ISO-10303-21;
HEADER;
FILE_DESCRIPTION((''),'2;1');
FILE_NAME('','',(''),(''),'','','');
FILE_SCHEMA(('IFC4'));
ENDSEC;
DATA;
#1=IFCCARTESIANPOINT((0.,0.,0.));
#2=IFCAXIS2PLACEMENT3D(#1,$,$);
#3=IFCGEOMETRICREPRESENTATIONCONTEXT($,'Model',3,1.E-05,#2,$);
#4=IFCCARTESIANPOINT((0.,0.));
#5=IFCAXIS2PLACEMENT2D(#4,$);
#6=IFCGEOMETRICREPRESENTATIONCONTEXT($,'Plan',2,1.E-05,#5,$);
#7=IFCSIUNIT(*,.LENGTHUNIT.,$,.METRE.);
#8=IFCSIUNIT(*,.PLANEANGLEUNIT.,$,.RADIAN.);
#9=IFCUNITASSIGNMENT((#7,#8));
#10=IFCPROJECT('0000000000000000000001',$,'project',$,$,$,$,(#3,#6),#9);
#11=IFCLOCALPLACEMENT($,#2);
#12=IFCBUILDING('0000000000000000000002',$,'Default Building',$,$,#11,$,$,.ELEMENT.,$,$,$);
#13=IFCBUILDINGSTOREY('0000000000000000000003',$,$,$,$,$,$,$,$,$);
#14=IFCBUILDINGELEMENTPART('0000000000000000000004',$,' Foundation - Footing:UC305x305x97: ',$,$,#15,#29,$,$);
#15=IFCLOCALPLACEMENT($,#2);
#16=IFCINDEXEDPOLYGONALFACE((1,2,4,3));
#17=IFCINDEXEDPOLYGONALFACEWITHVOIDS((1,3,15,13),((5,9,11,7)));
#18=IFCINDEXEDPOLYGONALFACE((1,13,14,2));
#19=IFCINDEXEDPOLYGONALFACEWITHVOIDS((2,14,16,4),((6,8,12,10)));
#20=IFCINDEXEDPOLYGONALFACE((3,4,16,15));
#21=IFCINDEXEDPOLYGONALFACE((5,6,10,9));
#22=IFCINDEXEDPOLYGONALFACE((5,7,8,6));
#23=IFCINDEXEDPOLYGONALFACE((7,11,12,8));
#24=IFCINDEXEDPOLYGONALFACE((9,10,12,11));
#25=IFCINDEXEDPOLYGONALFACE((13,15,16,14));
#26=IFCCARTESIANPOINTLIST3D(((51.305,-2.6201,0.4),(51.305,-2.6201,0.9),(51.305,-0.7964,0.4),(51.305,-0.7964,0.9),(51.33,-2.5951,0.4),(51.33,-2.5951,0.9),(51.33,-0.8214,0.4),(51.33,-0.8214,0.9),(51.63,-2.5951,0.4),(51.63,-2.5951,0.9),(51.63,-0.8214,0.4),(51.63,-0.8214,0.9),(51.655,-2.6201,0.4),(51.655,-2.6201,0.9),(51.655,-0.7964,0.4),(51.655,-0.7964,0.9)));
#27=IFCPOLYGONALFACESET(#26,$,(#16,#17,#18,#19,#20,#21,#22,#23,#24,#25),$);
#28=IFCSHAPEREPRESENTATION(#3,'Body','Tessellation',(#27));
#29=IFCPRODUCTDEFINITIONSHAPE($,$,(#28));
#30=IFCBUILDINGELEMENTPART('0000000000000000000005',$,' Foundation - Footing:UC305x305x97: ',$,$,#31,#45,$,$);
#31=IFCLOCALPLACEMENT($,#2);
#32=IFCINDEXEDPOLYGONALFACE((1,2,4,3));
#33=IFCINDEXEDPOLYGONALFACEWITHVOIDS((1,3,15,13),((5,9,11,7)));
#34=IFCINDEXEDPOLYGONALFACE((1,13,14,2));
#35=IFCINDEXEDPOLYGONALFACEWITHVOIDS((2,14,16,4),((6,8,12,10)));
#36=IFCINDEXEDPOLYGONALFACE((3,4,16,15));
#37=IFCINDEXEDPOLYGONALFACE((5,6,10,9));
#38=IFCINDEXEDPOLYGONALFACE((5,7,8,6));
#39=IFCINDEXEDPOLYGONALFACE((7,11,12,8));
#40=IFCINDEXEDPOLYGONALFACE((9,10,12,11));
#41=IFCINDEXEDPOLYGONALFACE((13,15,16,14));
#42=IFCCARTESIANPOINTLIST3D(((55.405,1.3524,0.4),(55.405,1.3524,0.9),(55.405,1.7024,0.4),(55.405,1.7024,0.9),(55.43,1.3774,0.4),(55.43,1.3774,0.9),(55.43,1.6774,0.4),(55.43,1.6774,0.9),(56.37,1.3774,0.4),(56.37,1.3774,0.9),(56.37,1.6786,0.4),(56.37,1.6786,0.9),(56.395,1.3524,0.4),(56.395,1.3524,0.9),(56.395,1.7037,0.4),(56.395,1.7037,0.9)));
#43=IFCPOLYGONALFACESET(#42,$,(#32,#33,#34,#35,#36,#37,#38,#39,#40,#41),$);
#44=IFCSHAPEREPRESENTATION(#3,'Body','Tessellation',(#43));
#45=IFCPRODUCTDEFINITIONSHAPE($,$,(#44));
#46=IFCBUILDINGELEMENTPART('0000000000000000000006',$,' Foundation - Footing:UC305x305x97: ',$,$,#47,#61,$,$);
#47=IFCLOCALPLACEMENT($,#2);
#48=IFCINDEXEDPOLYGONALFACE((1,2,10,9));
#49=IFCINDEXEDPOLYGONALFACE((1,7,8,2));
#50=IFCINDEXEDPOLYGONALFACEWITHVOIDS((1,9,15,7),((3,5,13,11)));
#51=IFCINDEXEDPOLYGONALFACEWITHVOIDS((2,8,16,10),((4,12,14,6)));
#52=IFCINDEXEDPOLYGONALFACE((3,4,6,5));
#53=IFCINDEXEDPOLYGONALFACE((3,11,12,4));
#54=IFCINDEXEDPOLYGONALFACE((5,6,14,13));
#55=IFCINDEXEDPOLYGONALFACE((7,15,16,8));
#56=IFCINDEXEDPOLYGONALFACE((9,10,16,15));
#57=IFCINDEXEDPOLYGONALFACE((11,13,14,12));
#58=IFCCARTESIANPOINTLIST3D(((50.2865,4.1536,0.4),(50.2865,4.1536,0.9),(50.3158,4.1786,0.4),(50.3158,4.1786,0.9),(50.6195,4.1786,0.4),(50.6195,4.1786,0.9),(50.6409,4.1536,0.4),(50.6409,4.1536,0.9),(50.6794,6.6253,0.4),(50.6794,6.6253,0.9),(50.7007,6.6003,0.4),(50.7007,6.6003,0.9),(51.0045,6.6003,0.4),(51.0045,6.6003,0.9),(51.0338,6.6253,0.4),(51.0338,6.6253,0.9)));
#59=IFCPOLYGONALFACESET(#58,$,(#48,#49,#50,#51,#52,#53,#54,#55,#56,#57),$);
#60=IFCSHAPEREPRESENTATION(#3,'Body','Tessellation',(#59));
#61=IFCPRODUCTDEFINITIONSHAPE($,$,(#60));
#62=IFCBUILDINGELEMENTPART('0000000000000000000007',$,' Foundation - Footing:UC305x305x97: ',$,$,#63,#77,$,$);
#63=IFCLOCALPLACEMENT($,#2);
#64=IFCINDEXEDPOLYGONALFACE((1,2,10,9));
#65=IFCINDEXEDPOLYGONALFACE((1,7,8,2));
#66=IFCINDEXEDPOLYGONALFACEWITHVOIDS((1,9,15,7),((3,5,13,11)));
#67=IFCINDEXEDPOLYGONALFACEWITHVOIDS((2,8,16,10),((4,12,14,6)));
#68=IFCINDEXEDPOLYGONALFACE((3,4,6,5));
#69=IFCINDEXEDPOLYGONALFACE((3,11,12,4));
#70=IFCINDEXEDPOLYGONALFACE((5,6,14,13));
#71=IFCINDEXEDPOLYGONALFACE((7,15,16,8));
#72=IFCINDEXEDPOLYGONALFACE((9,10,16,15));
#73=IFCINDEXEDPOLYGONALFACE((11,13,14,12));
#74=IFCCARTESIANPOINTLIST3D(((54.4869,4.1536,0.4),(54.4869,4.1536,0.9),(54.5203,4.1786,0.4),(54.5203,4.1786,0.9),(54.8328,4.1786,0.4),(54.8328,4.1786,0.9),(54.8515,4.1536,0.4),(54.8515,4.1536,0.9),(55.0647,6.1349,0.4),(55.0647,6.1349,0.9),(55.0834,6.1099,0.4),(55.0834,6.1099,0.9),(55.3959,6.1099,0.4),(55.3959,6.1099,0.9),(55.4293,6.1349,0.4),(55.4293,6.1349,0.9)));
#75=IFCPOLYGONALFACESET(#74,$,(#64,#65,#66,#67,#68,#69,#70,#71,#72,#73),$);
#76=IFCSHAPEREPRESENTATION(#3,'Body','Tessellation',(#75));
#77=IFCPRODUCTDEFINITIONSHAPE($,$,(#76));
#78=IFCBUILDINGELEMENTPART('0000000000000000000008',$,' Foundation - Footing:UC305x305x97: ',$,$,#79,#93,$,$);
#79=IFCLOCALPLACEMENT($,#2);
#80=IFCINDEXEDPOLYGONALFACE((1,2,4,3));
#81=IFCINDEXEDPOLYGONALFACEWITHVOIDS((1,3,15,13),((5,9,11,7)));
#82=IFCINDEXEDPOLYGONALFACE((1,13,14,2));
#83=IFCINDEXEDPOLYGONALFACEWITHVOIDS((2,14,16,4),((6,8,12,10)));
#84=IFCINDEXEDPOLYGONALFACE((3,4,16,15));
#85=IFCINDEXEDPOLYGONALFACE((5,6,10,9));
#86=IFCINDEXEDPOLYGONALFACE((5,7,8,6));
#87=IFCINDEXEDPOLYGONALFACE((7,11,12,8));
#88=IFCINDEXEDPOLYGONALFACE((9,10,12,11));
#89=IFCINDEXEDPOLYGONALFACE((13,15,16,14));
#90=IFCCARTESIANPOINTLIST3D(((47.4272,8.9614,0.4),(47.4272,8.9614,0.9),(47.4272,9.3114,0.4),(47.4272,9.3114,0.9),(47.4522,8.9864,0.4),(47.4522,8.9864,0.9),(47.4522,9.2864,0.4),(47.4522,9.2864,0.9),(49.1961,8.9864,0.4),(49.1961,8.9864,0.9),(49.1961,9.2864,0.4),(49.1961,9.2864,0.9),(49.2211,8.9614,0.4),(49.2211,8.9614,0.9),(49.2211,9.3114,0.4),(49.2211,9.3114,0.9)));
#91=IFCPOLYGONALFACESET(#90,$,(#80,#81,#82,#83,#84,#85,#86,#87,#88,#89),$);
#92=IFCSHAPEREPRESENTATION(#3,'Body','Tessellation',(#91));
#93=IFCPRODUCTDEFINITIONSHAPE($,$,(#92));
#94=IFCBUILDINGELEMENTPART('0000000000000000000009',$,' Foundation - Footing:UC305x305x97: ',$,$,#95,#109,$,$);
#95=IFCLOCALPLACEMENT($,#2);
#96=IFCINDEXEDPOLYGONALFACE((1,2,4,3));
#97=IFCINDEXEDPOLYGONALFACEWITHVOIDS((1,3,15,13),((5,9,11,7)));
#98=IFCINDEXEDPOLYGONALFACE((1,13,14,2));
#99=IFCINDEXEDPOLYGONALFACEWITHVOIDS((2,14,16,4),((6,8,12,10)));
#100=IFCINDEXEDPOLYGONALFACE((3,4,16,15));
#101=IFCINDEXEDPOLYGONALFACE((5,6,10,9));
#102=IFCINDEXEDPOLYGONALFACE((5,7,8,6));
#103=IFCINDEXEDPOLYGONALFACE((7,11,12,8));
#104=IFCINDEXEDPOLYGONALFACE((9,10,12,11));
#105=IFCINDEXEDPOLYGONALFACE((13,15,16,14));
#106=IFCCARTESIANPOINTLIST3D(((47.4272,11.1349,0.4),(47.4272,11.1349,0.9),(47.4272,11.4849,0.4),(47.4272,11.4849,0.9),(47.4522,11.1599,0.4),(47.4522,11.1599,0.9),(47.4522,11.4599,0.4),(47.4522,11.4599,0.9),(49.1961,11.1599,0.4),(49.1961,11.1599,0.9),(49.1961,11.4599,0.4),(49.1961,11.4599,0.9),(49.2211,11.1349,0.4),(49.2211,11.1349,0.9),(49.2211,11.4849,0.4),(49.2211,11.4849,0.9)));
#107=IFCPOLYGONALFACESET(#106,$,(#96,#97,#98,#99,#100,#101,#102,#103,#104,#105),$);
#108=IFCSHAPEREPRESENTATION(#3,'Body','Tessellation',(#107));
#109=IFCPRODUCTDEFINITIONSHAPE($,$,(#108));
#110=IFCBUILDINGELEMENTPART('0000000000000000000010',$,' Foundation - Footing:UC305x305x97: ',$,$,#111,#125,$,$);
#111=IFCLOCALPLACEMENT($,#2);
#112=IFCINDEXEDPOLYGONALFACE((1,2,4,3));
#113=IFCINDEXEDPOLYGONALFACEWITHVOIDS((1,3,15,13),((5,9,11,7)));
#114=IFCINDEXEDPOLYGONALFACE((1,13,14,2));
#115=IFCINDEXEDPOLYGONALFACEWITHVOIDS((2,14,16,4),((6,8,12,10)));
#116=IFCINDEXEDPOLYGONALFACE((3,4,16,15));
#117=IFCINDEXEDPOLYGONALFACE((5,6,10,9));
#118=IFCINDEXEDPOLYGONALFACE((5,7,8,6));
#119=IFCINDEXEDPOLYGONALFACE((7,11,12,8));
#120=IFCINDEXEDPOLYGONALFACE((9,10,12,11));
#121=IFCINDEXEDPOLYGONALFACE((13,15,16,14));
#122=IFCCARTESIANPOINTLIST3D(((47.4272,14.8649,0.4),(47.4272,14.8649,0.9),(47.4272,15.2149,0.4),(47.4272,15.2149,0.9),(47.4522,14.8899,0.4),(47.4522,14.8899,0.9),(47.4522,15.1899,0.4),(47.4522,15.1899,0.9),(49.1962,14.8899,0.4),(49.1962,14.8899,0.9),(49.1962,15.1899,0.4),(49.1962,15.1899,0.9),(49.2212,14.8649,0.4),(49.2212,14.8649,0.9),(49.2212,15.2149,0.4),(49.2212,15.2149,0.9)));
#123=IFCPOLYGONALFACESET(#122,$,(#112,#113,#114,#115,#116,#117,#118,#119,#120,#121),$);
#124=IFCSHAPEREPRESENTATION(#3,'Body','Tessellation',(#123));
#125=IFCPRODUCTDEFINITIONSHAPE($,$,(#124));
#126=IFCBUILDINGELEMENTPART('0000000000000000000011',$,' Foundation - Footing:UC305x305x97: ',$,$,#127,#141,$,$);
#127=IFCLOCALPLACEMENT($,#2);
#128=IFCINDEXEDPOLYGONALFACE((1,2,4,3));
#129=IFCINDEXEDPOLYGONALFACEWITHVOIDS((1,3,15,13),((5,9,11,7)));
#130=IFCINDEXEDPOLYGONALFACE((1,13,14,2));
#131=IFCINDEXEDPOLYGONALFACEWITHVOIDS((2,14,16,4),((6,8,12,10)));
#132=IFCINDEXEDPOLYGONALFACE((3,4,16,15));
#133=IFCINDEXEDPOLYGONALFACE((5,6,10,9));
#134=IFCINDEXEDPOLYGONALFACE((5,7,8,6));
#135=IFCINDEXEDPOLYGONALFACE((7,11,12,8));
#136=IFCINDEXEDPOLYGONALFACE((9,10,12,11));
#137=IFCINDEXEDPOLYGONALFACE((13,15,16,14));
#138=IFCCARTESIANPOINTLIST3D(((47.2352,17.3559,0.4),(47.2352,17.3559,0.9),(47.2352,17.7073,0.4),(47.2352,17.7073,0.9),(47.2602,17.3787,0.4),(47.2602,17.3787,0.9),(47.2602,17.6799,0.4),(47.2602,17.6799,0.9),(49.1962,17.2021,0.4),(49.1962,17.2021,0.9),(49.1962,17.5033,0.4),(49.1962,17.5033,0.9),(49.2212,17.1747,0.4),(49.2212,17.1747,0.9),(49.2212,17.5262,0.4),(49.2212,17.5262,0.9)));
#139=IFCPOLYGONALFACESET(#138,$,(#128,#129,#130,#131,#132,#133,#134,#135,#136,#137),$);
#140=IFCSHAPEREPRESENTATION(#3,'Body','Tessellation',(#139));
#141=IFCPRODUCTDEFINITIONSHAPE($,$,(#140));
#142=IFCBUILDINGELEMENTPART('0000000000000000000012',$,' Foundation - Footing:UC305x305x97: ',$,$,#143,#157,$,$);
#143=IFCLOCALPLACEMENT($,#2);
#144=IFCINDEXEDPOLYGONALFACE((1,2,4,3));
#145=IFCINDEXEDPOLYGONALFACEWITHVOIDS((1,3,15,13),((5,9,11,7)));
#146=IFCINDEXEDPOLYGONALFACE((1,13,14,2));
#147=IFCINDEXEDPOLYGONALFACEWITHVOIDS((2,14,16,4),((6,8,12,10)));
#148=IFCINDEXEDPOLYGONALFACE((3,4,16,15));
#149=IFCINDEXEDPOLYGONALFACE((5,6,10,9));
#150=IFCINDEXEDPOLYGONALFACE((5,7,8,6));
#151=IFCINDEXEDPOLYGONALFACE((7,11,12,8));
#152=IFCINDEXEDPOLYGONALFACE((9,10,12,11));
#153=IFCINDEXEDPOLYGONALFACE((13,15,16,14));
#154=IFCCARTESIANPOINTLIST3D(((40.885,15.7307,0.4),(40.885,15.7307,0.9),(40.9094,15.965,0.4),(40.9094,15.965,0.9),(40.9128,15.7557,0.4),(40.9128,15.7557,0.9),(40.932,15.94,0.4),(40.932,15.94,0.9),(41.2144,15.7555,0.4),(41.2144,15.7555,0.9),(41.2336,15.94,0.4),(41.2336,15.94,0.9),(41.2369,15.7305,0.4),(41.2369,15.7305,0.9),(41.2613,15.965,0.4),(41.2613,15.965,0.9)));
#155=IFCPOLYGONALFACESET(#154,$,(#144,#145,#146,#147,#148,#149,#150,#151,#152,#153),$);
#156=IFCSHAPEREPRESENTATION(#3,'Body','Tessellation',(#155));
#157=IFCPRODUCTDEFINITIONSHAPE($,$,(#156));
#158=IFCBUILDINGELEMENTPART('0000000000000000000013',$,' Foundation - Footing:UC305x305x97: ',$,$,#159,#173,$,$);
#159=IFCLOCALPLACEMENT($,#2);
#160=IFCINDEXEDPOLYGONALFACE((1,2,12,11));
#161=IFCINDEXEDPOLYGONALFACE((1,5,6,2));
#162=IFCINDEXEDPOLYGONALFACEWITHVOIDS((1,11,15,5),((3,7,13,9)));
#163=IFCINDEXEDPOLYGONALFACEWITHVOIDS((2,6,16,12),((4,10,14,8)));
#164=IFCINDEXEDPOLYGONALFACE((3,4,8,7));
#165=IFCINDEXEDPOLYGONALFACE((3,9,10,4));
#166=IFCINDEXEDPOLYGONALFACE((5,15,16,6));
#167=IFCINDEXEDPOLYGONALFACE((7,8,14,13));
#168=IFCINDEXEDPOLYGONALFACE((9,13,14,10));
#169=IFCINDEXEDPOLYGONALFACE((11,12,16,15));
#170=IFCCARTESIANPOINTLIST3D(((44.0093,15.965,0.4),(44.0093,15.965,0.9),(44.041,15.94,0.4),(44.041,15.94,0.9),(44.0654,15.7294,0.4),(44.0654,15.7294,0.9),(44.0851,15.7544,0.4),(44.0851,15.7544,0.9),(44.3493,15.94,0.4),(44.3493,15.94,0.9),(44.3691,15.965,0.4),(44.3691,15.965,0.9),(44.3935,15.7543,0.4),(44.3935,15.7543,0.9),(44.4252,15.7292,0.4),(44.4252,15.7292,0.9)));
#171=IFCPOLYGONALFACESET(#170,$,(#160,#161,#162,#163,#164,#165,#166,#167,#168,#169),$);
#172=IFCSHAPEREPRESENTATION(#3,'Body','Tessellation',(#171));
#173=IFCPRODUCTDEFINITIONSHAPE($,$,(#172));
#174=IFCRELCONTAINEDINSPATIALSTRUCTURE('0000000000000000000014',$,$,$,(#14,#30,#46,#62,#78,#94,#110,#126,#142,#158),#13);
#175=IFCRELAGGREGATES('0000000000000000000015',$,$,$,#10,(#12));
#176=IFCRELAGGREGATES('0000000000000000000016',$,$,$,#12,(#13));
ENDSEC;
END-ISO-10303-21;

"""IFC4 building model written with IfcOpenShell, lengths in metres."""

from ifc_helpers import new_model, si_unit, origin, origin_2d, place, context, project, spatial, polyline, outline, extrude, element, save


model = new_model("IFC4")

# Units and contexts
model_context = context("Model", 3, precision=1e-05, world=origin())
plan_context = context("Plan", 2, precision=1e-05, world=origin_2d())
ifc_project = project(units=[si_unit("LENGTHUNIT", "METRE"), si_unit("PLANEANGLEUNIT", "RADIAN")], contexts=[model_context, plan_context])

# Building, storey
building_placement = place(None, origin())
building = spatial("IfcBuilding", under=ifc_project, at=building_placement, Name="Default Building", CompositionType="ELEMENT")
storey = spatial("IfcBuildingStorey", under=building)

# Building element parts, openings
building_element_part_1 = element("IfcBuildingElementPart", 1, inside=storey, Name=" Foundation - Footing:UC305x305x97: ", context=model_context, shape_type="SweptSolid", body=[
    extrude(outline(polyline([(51.305, -2.6201, 0.4), (51.655, -2.6201, 0.4), (51.655, -0.7964, 0.4), (51.305, -0.7964, 0.4), (51.305, -2.6201, 0.4)])), None, (0.0, 0.0, 1.0), 0.5),
])
element("IfcOpeningElement", 2, inside=storey, cuts=building_element_part_1, context=model_context, shape_type="SweptSolid", body=[
    extrude(outline(polyline([(51.33, -2.5951, 0.4), (51.63, -2.5951, 0.4), (51.63, -0.8214, 0.4), (51.33, -0.8214, 0.4), (51.33, -2.5951, 0.4)])), None, (0.0, 0.0, 1.0), 0.5),
])
building_element_part_2 = element("IfcBuildingElementPart", 3, inside=storey, Name=" Foundation - Footing:UC305x305x97: ", context=model_context, shape_type="SweptSolid", body=[
    extrude(outline(polyline([(55.405, 1.3524, 0.4), (55.405, 1.7024, 0.4), (56.395, 1.7037, 0.4), (56.395, 1.3524, 0.4), (55.405, 1.3524, 0.4)])), None, (0.0, 0.0, 1.0), 0.5),
])
element("IfcOpeningElement", 4, inside=storey, cuts=building_element_part_2, context=model_context, shape_type="SweptSolid", body=[
    extrude(outline(polyline([(55.43, 1.3774, 0.4), (55.43, 1.6774, 0.4), (56.37, 1.6786, 0.4), (56.37, 1.3774, 0.4), (55.43, 1.3774, 0.4)])), None, (0.0, 0.0, 1.0), 0.5),
])
building_element_part_3 = element("IfcBuildingElementPart", 5, inside=storey, Name=" Foundation - Footing:UC305x305x97: ", context=model_context, shape_type="SweptSolid", body=[
    extrude(outline(polyline([(50.2865, 4.1536, 0.4), (50.6794, 6.6253, 0.4), (51.0338, 6.6253, 0.4), (50.6409, 4.1536, 0.4), (50.2865, 4.1536, 0.4)])), None, (0.0, 0.0, 1.0), 0.5),
])
element("IfcOpeningElement", 6, inside=storey, cuts=building_element_part_3, context=model_context, shape_type="SweptSolid", body=[
    extrude(outline(polyline([(50.3158, 4.1786, 0.4), (50.7007, 6.6003, 0.4), (51.0045, 6.6003, 0.4), (50.6195, 4.1786, 0.4), (50.3158, 4.1786, 0.4)])), None, (0.0, 0.0, 1.0), 0.5),
])
building_element_part_4 = element("IfcBuildingElementPart", 7, inside=storey, Name=" Foundation - Footing:UC305x305x97: ", context=model_context, shape_type="SweptSolid", body=[
    extrude(outline(polyline([(54.8515, 4.1536, 0.4), (54.4869, 4.1536, 0.4), (55.0647, 6.1349, 0.4), (55.4293, 6.1349, 0.4), (54.8515, 4.1536, 0.4)])), None, (0.0, 0.0, 1.0), 0.5),
])
element("IfcOpeningElement", 8, inside=storey, cuts=building_element_part_4, context=model_context, shape_type="SweptSolid", body=[
    extrude(outline(polyline([(54.8328, 4.1786, 0.4), (54.5203, 4.1786, 0.4), (55.0834, 6.1099, 0.4), (55.3959, 6.1099, 0.4), (54.8328, 4.1786, 0.4)])), None, (0.0, 0.0, 1.0), 0.5),
])
building_element_part_5 = element("IfcBuildingElementPart", 9, inside=storey, Name=" Foundation - Footing:UC305x305x97: ", context=model_context, shape_type="SweptSolid", body=[
    extrude(outline(polyline([(47.4272, 8.9614, 0.4), (49.2211, 8.9614, 0.4), (49.2211, 9.3114, 0.4), (47.4272, 9.3114, 0.4), (47.4272, 8.9614, 0.4)])), None, (0.0, 0.0, 1.0), 0.5),
])
element("IfcOpeningElement", 10, inside=storey, cuts=building_element_part_5, context=model_context, shape_type="SweptSolid", body=[
    extrude(outline(polyline([(47.4522, 8.9864, 0.4), (49.1961, 8.9864, 0.4), (49.1961, 9.2864, 0.4), (47.4522, 9.2864, 0.4), (47.4522, 8.9864, 0.4)])), None, (0.0, 0.0, 1.0), 0.5),
])
building_element_part_6 = element("IfcBuildingElementPart", 11, inside=storey, Name=" Foundation - Footing:UC305x305x97: ", context=model_context, shape_type="SweptSolid", body=[
    extrude(outline(polyline([(47.4272, 11.1349, 0.4), (47.4272, 11.4849, 0.4), (49.2211, 11.4849, 0.4), (49.2211, 11.1349, 0.4), (47.4272, 11.1349, 0.4)])), None, (0.0, 0.0, 1.0), 0.5),
])
element("IfcOpeningElement", 12, inside=storey, cuts=building_element_part_6, context=model_context, shape_type="SweptSolid", body=[
    extrude(outline(polyline([(47.4522, 11.1599, 0.4), (47.4522, 11.4599, 0.4), (49.1961, 11.4599, 0.4), (49.1961, 11.1599, 0.4), (47.4522, 11.1599, 0.4)])), None, (0.0, 0.0, 1.0), 0.5),
])
building_element_part_7 = element("IfcBuildingElementPart", 13, inside=storey, Name=" Foundation - Footing:UC305x305x97: ", context=model_context, shape_type="SweptSolid", body=[
    extrude(outline(polyline([(47.4272, 14.8649, 0.4), (47.4272, 15.2149, 0.4), (49.2212, 15.2149, 0.4), (49.2212, 14.8649, 0.4), (47.4272, 14.8649, 0.4)])), None, (0.0, 0.0, 1.0), 0.5),
])
element("IfcOpeningElement", 14, inside=storey, cuts=building_element_part_7, context=model_context, shape_type="SweptSolid", body=[
    extrude(outline(polyline([(47.4522, 14.8899, 0.4), (47.4522, 15.1899, 0.4), (49.1962, 15.1899, 0.4), (49.1962, 14.8899, 0.4), (47.4522, 14.8899, 0.4)])), None, (0.0, 0.0, 1.0), 0.5),
])
building_element_part_8 = element("IfcBuildingElementPart", 15, inside=storey, Name=" Foundation - Footing:UC305x305x97: ", context=model_context, shape_type="SweptSolid", body=[
    extrude(outline(polyline([(47.2352, 17.3559, 0.4), (47.2352, 17.7073, 0.4), (49.2212, 17.5262, 0.4), (49.2212, 17.1747, 0.4), (47.2352, 17.3559, 0.4)])), None, (0.0, 0.0, 1.0), 0.5),
])
element("IfcOpeningElement", 16, inside=storey, cuts=building_element_part_8, context=model_context, shape_type="SweptSolid", body=[
    extrude(outline(polyline([(47.2602, 17.3787, 0.4), (47.2602, 17.6799, 0.4), (49.1962, 17.5033, 0.4), (49.1962, 17.2021, 0.4), (47.2602, 17.3787, 0.4)])), None, (0.0, 0.0, 1.0), 0.5),
])
building_element_part_9 = element("IfcBuildingElementPart", 17, inside=storey, Name=" Foundation - Footing:UC305x305x97: ", context=model_context, shape_type="SweptSolid", body=[
    extrude(outline(polyline([(40.885, 15.7307, 0.4), (40.9094, 15.965, 0.4), (41.2613, 15.965, 0.4), (41.2369, 15.7305, 0.4), (40.885, 15.7307, 0.4)])), None, (0.0, 0.0, 1.0), 0.5),
])
element("IfcOpeningElement", 18, inside=storey, cuts=building_element_part_9, context=model_context, shape_type="SweptSolid", body=[
    extrude(outline(polyline([(40.9128, 15.7557, 0.4), (40.932, 15.94, 0.4), (41.2336, 15.94, 0.4), (41.2144, 15.7555, 0.4), (40.9128, 15.7557, 0.4)])), None, (0.0, 0.0, 1.0), 0.5),
])
building_element_part_10 = element("IfcBuildingElementPart", 19, inside=storey, Name=" Foundation - Footing:UC305x305x97: ", context=model_context, shape_type="SweptSolid", body=[
    extrude(outline(polyline([(44.0654, 15.7294, 0.4), (44.0093, 15.965, 0.4), (44.3691, 15.965, 0.4), (44.4252, 15.7292, 0.4), (44.0654, 15.7294, 0.4)])), None, (0.0, 0.0, 1.0), 0.5),
])
element("IfcOpeningElement", 20, inside=storey, cuts=building_element_part_10, context=model_context, shape_type="SweptSolid", body=[
    extrude(outline(polyline([(44.0851, 15.7544, 0.4), (44.041, 15.94, 0.4), (44.3493, 15.94, 0.4), (44.3935, 15.7543, 0.4), (44.0851, 15.7544, 0.4)])), None, (0.0, 0.0, 1.0), 0.5),
])

save(model, "model.ifc")
